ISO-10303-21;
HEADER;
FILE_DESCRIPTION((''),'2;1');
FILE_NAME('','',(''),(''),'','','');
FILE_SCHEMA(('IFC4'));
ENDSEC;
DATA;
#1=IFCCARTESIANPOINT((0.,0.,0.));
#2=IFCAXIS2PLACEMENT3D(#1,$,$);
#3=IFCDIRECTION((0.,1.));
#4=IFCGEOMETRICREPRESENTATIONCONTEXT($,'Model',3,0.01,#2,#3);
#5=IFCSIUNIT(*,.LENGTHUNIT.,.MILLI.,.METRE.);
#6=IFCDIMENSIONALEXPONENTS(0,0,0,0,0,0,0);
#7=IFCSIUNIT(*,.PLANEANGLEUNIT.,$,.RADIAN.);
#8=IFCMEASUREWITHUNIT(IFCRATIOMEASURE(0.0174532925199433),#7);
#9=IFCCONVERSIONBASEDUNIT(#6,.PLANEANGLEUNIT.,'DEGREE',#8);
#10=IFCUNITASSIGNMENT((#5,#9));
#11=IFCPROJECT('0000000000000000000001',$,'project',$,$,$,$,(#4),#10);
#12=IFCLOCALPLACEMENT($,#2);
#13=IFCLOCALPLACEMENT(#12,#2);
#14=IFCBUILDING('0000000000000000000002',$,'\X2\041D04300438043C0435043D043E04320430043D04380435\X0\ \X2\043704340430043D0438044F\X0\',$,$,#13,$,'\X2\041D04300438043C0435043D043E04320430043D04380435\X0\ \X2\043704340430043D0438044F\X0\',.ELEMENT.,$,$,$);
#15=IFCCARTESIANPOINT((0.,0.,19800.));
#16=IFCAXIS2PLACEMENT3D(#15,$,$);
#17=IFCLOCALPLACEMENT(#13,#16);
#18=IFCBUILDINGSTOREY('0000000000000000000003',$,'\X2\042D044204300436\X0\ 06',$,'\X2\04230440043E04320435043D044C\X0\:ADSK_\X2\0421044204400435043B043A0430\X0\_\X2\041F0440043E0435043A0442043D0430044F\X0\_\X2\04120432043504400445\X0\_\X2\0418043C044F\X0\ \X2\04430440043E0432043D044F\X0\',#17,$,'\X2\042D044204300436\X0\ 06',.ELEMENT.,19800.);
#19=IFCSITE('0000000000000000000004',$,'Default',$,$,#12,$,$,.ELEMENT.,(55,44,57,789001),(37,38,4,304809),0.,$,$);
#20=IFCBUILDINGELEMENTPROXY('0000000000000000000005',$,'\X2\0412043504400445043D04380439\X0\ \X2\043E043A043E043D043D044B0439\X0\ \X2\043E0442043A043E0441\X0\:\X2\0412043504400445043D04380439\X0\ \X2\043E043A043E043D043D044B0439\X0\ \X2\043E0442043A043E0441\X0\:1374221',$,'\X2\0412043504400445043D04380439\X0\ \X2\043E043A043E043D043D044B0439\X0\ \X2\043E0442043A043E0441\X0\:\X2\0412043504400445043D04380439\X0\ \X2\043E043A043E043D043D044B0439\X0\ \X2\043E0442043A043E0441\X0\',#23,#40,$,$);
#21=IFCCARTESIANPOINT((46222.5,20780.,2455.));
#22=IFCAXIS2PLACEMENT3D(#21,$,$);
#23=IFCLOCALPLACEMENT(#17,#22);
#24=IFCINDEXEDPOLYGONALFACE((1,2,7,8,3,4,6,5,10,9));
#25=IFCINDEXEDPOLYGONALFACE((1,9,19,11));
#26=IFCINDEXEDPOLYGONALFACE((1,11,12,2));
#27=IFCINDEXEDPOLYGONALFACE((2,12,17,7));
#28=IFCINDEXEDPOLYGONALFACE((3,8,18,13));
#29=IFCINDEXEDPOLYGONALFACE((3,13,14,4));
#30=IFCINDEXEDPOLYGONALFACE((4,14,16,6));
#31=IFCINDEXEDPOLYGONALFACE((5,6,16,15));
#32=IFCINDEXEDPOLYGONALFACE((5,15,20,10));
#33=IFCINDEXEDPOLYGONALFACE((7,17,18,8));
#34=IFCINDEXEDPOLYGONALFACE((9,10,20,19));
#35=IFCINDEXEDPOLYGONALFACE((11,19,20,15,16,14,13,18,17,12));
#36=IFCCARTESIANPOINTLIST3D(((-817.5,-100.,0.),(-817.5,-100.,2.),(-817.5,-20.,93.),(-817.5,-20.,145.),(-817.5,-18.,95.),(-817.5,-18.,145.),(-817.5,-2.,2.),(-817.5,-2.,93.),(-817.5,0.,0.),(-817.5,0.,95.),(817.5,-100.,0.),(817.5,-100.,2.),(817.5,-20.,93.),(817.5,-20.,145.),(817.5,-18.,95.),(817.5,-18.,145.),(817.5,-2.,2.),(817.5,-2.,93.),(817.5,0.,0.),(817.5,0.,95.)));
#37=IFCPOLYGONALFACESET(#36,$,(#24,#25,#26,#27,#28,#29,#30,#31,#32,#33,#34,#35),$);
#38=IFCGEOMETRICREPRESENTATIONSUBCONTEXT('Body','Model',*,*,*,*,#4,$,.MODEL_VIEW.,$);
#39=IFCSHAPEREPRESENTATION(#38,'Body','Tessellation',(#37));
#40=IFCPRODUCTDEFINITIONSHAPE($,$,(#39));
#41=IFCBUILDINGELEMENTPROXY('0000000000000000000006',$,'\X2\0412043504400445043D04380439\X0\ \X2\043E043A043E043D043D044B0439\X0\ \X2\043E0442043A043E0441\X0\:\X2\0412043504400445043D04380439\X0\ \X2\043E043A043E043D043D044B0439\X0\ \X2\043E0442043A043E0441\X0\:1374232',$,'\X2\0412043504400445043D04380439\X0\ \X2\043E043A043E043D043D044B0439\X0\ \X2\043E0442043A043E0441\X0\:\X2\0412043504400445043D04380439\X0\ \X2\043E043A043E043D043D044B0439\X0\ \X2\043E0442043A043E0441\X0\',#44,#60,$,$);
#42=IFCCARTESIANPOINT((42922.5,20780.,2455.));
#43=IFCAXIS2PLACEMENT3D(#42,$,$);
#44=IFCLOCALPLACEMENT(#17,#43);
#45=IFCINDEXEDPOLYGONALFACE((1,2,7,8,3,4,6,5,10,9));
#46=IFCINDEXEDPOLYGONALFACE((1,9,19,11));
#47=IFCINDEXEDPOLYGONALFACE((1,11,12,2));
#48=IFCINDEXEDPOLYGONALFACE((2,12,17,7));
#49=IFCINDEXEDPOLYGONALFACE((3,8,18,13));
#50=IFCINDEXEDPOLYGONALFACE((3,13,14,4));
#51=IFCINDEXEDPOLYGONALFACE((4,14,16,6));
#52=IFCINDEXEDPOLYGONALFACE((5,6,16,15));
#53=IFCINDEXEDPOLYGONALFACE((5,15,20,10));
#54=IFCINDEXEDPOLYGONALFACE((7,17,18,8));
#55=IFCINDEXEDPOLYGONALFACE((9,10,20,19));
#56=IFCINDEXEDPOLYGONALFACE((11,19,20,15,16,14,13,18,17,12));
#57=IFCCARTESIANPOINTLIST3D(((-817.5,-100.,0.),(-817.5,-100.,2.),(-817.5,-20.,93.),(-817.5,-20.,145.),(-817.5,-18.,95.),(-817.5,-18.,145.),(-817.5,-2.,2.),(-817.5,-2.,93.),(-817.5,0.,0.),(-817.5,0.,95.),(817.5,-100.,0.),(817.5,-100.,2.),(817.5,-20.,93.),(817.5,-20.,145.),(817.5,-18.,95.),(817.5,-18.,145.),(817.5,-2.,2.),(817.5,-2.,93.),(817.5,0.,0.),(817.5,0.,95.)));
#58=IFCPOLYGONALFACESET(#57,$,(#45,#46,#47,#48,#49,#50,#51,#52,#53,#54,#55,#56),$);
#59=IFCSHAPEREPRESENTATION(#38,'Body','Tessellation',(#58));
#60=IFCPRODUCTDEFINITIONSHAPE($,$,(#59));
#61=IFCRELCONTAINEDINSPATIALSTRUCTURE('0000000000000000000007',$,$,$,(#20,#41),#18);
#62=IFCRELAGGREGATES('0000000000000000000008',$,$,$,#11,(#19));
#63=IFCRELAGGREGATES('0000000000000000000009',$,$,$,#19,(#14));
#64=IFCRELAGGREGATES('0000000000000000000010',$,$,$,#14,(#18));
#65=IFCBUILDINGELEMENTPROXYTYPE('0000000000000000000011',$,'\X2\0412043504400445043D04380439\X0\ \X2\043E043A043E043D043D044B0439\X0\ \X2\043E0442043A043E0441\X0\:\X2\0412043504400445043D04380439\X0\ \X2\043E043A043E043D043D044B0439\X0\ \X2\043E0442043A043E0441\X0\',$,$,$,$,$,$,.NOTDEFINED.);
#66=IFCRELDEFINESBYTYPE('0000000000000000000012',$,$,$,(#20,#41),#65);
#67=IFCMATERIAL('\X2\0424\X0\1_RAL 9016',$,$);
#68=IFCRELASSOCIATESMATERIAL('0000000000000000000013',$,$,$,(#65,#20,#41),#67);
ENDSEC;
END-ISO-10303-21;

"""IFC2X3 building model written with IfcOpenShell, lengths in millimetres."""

from ifc_helpers import new_model, entity, si_unit, converted_unit, direction, frame, origin, place, context, subcontext, project, spatial, polyline, outline, extrude, source, transform, mapped, material, type_object, type_shapes, element, save


model = new_model("IFC2X3")

# Units and contexts
model_context = context("Model", 3, precision=0.01, world=origin(), true_north=direction((0.0, 1.0)))
body_context = subcontext(model_context, "Body", "Model", "MODEL_VIEW")
ifc_project = project(units=[si_unit("LENGTHUNIT", "METRE", prefix="MILLI"), converted_unit("PLANEANGLEUNIT", "DEGREE", entity("IfcRatioMeasure", 0.0174532925199433), si_unit("PLANEANGLEUNIT", "RADIAN"), dimensions=[0, 0, 0, 0, 0, 0, 0])], contexts=[model_context])

# Site, building, storey
site_placement = place(None, origin())
site = spatial("IfcSite", under=ifc_project, at=site_placement, Name="Default", CompositionType="ELEMENT", RefLatitude=(55, 44, 57, 789001), RefLongitude=(37, 38, 4, 304809), RefElevation=0.0)
building_placement = place(site_placement, origin())
building = spatial("IfcBuilding", under=site, at=building_placement, Name="Наименование здания", LongName="Наименование здания", CompositionType="ELEMENT")
storey_placement = place(building_placement, frame((0.0, 0.0, 19800.0)))
storey = spatial("IfcBuildingStorey", under=building, at=storey_placement, Name="Этаж 06", ObjectType="Уровень:ADSK_Стрелка_Проектная_Вверх_Имя уровня", LongName="Этаж 06", CompositionType="ELEMENT", Elevation=19800.0)

# Building element proxies
ifc_material_1 = material(Name="Ф1_RAL 9016")
building_element_proxy_type_1 = type_object("IfcBuildingElementProxyType", Name="Верхний оконный откос:Верхний оконный откос", PredefinedType="NOTDEFINED", material=ifc_material_1)
shared_shape_1 = source(origin(), body_context, "Body", "SweptSolid", [
    extrude(outline(polyline([(28.0, -10.0), (78.0, -10.0), (78.0, -8.0), (26.0, -8.0), (26.0, -26.0), (-65.0, -26.0), (-65.0, 72.0), (-67.0, 72.0), (-67.0, -28.0), (28.0, -28.0), (28.0, -10.0)])), frame((-817.5, -28.0, 67.0), z_axis=(1.0, 0.0, 0.0), x_axis=(0.0, 0.0, 1.0)), (0.0, 0.0, 1.0), 1635.0),
])
type_shapes(building_element_proxy_type_1, [shared_shape_1])
for number, where, name in (
    (1, (46222.5, 20780.0, 2455.0), "Верхний оконный откос:Верхний оконный откос:1374221"),
    (2, (42922.5, 20780.0, 2455.0), "Верхний оконный откос:Верхний оконный откос:1374232"),
):
    element("IfcBuildingElementProxy", number, at=place(storey_placement, frame(where)), inside=storey, type_object=building_element_proxy_type_1, material=ifc_material_1, Name=name, ObjectType="Верхний оконный откос:Верхний оконный откос", context=body_context, shape_type="MappedRepresentation", body=[
        mapped(shared_shape_1, transform((0.0, 0.0, 0.0), scale=1.0)),
    ])

save(model, "model.ifc")
